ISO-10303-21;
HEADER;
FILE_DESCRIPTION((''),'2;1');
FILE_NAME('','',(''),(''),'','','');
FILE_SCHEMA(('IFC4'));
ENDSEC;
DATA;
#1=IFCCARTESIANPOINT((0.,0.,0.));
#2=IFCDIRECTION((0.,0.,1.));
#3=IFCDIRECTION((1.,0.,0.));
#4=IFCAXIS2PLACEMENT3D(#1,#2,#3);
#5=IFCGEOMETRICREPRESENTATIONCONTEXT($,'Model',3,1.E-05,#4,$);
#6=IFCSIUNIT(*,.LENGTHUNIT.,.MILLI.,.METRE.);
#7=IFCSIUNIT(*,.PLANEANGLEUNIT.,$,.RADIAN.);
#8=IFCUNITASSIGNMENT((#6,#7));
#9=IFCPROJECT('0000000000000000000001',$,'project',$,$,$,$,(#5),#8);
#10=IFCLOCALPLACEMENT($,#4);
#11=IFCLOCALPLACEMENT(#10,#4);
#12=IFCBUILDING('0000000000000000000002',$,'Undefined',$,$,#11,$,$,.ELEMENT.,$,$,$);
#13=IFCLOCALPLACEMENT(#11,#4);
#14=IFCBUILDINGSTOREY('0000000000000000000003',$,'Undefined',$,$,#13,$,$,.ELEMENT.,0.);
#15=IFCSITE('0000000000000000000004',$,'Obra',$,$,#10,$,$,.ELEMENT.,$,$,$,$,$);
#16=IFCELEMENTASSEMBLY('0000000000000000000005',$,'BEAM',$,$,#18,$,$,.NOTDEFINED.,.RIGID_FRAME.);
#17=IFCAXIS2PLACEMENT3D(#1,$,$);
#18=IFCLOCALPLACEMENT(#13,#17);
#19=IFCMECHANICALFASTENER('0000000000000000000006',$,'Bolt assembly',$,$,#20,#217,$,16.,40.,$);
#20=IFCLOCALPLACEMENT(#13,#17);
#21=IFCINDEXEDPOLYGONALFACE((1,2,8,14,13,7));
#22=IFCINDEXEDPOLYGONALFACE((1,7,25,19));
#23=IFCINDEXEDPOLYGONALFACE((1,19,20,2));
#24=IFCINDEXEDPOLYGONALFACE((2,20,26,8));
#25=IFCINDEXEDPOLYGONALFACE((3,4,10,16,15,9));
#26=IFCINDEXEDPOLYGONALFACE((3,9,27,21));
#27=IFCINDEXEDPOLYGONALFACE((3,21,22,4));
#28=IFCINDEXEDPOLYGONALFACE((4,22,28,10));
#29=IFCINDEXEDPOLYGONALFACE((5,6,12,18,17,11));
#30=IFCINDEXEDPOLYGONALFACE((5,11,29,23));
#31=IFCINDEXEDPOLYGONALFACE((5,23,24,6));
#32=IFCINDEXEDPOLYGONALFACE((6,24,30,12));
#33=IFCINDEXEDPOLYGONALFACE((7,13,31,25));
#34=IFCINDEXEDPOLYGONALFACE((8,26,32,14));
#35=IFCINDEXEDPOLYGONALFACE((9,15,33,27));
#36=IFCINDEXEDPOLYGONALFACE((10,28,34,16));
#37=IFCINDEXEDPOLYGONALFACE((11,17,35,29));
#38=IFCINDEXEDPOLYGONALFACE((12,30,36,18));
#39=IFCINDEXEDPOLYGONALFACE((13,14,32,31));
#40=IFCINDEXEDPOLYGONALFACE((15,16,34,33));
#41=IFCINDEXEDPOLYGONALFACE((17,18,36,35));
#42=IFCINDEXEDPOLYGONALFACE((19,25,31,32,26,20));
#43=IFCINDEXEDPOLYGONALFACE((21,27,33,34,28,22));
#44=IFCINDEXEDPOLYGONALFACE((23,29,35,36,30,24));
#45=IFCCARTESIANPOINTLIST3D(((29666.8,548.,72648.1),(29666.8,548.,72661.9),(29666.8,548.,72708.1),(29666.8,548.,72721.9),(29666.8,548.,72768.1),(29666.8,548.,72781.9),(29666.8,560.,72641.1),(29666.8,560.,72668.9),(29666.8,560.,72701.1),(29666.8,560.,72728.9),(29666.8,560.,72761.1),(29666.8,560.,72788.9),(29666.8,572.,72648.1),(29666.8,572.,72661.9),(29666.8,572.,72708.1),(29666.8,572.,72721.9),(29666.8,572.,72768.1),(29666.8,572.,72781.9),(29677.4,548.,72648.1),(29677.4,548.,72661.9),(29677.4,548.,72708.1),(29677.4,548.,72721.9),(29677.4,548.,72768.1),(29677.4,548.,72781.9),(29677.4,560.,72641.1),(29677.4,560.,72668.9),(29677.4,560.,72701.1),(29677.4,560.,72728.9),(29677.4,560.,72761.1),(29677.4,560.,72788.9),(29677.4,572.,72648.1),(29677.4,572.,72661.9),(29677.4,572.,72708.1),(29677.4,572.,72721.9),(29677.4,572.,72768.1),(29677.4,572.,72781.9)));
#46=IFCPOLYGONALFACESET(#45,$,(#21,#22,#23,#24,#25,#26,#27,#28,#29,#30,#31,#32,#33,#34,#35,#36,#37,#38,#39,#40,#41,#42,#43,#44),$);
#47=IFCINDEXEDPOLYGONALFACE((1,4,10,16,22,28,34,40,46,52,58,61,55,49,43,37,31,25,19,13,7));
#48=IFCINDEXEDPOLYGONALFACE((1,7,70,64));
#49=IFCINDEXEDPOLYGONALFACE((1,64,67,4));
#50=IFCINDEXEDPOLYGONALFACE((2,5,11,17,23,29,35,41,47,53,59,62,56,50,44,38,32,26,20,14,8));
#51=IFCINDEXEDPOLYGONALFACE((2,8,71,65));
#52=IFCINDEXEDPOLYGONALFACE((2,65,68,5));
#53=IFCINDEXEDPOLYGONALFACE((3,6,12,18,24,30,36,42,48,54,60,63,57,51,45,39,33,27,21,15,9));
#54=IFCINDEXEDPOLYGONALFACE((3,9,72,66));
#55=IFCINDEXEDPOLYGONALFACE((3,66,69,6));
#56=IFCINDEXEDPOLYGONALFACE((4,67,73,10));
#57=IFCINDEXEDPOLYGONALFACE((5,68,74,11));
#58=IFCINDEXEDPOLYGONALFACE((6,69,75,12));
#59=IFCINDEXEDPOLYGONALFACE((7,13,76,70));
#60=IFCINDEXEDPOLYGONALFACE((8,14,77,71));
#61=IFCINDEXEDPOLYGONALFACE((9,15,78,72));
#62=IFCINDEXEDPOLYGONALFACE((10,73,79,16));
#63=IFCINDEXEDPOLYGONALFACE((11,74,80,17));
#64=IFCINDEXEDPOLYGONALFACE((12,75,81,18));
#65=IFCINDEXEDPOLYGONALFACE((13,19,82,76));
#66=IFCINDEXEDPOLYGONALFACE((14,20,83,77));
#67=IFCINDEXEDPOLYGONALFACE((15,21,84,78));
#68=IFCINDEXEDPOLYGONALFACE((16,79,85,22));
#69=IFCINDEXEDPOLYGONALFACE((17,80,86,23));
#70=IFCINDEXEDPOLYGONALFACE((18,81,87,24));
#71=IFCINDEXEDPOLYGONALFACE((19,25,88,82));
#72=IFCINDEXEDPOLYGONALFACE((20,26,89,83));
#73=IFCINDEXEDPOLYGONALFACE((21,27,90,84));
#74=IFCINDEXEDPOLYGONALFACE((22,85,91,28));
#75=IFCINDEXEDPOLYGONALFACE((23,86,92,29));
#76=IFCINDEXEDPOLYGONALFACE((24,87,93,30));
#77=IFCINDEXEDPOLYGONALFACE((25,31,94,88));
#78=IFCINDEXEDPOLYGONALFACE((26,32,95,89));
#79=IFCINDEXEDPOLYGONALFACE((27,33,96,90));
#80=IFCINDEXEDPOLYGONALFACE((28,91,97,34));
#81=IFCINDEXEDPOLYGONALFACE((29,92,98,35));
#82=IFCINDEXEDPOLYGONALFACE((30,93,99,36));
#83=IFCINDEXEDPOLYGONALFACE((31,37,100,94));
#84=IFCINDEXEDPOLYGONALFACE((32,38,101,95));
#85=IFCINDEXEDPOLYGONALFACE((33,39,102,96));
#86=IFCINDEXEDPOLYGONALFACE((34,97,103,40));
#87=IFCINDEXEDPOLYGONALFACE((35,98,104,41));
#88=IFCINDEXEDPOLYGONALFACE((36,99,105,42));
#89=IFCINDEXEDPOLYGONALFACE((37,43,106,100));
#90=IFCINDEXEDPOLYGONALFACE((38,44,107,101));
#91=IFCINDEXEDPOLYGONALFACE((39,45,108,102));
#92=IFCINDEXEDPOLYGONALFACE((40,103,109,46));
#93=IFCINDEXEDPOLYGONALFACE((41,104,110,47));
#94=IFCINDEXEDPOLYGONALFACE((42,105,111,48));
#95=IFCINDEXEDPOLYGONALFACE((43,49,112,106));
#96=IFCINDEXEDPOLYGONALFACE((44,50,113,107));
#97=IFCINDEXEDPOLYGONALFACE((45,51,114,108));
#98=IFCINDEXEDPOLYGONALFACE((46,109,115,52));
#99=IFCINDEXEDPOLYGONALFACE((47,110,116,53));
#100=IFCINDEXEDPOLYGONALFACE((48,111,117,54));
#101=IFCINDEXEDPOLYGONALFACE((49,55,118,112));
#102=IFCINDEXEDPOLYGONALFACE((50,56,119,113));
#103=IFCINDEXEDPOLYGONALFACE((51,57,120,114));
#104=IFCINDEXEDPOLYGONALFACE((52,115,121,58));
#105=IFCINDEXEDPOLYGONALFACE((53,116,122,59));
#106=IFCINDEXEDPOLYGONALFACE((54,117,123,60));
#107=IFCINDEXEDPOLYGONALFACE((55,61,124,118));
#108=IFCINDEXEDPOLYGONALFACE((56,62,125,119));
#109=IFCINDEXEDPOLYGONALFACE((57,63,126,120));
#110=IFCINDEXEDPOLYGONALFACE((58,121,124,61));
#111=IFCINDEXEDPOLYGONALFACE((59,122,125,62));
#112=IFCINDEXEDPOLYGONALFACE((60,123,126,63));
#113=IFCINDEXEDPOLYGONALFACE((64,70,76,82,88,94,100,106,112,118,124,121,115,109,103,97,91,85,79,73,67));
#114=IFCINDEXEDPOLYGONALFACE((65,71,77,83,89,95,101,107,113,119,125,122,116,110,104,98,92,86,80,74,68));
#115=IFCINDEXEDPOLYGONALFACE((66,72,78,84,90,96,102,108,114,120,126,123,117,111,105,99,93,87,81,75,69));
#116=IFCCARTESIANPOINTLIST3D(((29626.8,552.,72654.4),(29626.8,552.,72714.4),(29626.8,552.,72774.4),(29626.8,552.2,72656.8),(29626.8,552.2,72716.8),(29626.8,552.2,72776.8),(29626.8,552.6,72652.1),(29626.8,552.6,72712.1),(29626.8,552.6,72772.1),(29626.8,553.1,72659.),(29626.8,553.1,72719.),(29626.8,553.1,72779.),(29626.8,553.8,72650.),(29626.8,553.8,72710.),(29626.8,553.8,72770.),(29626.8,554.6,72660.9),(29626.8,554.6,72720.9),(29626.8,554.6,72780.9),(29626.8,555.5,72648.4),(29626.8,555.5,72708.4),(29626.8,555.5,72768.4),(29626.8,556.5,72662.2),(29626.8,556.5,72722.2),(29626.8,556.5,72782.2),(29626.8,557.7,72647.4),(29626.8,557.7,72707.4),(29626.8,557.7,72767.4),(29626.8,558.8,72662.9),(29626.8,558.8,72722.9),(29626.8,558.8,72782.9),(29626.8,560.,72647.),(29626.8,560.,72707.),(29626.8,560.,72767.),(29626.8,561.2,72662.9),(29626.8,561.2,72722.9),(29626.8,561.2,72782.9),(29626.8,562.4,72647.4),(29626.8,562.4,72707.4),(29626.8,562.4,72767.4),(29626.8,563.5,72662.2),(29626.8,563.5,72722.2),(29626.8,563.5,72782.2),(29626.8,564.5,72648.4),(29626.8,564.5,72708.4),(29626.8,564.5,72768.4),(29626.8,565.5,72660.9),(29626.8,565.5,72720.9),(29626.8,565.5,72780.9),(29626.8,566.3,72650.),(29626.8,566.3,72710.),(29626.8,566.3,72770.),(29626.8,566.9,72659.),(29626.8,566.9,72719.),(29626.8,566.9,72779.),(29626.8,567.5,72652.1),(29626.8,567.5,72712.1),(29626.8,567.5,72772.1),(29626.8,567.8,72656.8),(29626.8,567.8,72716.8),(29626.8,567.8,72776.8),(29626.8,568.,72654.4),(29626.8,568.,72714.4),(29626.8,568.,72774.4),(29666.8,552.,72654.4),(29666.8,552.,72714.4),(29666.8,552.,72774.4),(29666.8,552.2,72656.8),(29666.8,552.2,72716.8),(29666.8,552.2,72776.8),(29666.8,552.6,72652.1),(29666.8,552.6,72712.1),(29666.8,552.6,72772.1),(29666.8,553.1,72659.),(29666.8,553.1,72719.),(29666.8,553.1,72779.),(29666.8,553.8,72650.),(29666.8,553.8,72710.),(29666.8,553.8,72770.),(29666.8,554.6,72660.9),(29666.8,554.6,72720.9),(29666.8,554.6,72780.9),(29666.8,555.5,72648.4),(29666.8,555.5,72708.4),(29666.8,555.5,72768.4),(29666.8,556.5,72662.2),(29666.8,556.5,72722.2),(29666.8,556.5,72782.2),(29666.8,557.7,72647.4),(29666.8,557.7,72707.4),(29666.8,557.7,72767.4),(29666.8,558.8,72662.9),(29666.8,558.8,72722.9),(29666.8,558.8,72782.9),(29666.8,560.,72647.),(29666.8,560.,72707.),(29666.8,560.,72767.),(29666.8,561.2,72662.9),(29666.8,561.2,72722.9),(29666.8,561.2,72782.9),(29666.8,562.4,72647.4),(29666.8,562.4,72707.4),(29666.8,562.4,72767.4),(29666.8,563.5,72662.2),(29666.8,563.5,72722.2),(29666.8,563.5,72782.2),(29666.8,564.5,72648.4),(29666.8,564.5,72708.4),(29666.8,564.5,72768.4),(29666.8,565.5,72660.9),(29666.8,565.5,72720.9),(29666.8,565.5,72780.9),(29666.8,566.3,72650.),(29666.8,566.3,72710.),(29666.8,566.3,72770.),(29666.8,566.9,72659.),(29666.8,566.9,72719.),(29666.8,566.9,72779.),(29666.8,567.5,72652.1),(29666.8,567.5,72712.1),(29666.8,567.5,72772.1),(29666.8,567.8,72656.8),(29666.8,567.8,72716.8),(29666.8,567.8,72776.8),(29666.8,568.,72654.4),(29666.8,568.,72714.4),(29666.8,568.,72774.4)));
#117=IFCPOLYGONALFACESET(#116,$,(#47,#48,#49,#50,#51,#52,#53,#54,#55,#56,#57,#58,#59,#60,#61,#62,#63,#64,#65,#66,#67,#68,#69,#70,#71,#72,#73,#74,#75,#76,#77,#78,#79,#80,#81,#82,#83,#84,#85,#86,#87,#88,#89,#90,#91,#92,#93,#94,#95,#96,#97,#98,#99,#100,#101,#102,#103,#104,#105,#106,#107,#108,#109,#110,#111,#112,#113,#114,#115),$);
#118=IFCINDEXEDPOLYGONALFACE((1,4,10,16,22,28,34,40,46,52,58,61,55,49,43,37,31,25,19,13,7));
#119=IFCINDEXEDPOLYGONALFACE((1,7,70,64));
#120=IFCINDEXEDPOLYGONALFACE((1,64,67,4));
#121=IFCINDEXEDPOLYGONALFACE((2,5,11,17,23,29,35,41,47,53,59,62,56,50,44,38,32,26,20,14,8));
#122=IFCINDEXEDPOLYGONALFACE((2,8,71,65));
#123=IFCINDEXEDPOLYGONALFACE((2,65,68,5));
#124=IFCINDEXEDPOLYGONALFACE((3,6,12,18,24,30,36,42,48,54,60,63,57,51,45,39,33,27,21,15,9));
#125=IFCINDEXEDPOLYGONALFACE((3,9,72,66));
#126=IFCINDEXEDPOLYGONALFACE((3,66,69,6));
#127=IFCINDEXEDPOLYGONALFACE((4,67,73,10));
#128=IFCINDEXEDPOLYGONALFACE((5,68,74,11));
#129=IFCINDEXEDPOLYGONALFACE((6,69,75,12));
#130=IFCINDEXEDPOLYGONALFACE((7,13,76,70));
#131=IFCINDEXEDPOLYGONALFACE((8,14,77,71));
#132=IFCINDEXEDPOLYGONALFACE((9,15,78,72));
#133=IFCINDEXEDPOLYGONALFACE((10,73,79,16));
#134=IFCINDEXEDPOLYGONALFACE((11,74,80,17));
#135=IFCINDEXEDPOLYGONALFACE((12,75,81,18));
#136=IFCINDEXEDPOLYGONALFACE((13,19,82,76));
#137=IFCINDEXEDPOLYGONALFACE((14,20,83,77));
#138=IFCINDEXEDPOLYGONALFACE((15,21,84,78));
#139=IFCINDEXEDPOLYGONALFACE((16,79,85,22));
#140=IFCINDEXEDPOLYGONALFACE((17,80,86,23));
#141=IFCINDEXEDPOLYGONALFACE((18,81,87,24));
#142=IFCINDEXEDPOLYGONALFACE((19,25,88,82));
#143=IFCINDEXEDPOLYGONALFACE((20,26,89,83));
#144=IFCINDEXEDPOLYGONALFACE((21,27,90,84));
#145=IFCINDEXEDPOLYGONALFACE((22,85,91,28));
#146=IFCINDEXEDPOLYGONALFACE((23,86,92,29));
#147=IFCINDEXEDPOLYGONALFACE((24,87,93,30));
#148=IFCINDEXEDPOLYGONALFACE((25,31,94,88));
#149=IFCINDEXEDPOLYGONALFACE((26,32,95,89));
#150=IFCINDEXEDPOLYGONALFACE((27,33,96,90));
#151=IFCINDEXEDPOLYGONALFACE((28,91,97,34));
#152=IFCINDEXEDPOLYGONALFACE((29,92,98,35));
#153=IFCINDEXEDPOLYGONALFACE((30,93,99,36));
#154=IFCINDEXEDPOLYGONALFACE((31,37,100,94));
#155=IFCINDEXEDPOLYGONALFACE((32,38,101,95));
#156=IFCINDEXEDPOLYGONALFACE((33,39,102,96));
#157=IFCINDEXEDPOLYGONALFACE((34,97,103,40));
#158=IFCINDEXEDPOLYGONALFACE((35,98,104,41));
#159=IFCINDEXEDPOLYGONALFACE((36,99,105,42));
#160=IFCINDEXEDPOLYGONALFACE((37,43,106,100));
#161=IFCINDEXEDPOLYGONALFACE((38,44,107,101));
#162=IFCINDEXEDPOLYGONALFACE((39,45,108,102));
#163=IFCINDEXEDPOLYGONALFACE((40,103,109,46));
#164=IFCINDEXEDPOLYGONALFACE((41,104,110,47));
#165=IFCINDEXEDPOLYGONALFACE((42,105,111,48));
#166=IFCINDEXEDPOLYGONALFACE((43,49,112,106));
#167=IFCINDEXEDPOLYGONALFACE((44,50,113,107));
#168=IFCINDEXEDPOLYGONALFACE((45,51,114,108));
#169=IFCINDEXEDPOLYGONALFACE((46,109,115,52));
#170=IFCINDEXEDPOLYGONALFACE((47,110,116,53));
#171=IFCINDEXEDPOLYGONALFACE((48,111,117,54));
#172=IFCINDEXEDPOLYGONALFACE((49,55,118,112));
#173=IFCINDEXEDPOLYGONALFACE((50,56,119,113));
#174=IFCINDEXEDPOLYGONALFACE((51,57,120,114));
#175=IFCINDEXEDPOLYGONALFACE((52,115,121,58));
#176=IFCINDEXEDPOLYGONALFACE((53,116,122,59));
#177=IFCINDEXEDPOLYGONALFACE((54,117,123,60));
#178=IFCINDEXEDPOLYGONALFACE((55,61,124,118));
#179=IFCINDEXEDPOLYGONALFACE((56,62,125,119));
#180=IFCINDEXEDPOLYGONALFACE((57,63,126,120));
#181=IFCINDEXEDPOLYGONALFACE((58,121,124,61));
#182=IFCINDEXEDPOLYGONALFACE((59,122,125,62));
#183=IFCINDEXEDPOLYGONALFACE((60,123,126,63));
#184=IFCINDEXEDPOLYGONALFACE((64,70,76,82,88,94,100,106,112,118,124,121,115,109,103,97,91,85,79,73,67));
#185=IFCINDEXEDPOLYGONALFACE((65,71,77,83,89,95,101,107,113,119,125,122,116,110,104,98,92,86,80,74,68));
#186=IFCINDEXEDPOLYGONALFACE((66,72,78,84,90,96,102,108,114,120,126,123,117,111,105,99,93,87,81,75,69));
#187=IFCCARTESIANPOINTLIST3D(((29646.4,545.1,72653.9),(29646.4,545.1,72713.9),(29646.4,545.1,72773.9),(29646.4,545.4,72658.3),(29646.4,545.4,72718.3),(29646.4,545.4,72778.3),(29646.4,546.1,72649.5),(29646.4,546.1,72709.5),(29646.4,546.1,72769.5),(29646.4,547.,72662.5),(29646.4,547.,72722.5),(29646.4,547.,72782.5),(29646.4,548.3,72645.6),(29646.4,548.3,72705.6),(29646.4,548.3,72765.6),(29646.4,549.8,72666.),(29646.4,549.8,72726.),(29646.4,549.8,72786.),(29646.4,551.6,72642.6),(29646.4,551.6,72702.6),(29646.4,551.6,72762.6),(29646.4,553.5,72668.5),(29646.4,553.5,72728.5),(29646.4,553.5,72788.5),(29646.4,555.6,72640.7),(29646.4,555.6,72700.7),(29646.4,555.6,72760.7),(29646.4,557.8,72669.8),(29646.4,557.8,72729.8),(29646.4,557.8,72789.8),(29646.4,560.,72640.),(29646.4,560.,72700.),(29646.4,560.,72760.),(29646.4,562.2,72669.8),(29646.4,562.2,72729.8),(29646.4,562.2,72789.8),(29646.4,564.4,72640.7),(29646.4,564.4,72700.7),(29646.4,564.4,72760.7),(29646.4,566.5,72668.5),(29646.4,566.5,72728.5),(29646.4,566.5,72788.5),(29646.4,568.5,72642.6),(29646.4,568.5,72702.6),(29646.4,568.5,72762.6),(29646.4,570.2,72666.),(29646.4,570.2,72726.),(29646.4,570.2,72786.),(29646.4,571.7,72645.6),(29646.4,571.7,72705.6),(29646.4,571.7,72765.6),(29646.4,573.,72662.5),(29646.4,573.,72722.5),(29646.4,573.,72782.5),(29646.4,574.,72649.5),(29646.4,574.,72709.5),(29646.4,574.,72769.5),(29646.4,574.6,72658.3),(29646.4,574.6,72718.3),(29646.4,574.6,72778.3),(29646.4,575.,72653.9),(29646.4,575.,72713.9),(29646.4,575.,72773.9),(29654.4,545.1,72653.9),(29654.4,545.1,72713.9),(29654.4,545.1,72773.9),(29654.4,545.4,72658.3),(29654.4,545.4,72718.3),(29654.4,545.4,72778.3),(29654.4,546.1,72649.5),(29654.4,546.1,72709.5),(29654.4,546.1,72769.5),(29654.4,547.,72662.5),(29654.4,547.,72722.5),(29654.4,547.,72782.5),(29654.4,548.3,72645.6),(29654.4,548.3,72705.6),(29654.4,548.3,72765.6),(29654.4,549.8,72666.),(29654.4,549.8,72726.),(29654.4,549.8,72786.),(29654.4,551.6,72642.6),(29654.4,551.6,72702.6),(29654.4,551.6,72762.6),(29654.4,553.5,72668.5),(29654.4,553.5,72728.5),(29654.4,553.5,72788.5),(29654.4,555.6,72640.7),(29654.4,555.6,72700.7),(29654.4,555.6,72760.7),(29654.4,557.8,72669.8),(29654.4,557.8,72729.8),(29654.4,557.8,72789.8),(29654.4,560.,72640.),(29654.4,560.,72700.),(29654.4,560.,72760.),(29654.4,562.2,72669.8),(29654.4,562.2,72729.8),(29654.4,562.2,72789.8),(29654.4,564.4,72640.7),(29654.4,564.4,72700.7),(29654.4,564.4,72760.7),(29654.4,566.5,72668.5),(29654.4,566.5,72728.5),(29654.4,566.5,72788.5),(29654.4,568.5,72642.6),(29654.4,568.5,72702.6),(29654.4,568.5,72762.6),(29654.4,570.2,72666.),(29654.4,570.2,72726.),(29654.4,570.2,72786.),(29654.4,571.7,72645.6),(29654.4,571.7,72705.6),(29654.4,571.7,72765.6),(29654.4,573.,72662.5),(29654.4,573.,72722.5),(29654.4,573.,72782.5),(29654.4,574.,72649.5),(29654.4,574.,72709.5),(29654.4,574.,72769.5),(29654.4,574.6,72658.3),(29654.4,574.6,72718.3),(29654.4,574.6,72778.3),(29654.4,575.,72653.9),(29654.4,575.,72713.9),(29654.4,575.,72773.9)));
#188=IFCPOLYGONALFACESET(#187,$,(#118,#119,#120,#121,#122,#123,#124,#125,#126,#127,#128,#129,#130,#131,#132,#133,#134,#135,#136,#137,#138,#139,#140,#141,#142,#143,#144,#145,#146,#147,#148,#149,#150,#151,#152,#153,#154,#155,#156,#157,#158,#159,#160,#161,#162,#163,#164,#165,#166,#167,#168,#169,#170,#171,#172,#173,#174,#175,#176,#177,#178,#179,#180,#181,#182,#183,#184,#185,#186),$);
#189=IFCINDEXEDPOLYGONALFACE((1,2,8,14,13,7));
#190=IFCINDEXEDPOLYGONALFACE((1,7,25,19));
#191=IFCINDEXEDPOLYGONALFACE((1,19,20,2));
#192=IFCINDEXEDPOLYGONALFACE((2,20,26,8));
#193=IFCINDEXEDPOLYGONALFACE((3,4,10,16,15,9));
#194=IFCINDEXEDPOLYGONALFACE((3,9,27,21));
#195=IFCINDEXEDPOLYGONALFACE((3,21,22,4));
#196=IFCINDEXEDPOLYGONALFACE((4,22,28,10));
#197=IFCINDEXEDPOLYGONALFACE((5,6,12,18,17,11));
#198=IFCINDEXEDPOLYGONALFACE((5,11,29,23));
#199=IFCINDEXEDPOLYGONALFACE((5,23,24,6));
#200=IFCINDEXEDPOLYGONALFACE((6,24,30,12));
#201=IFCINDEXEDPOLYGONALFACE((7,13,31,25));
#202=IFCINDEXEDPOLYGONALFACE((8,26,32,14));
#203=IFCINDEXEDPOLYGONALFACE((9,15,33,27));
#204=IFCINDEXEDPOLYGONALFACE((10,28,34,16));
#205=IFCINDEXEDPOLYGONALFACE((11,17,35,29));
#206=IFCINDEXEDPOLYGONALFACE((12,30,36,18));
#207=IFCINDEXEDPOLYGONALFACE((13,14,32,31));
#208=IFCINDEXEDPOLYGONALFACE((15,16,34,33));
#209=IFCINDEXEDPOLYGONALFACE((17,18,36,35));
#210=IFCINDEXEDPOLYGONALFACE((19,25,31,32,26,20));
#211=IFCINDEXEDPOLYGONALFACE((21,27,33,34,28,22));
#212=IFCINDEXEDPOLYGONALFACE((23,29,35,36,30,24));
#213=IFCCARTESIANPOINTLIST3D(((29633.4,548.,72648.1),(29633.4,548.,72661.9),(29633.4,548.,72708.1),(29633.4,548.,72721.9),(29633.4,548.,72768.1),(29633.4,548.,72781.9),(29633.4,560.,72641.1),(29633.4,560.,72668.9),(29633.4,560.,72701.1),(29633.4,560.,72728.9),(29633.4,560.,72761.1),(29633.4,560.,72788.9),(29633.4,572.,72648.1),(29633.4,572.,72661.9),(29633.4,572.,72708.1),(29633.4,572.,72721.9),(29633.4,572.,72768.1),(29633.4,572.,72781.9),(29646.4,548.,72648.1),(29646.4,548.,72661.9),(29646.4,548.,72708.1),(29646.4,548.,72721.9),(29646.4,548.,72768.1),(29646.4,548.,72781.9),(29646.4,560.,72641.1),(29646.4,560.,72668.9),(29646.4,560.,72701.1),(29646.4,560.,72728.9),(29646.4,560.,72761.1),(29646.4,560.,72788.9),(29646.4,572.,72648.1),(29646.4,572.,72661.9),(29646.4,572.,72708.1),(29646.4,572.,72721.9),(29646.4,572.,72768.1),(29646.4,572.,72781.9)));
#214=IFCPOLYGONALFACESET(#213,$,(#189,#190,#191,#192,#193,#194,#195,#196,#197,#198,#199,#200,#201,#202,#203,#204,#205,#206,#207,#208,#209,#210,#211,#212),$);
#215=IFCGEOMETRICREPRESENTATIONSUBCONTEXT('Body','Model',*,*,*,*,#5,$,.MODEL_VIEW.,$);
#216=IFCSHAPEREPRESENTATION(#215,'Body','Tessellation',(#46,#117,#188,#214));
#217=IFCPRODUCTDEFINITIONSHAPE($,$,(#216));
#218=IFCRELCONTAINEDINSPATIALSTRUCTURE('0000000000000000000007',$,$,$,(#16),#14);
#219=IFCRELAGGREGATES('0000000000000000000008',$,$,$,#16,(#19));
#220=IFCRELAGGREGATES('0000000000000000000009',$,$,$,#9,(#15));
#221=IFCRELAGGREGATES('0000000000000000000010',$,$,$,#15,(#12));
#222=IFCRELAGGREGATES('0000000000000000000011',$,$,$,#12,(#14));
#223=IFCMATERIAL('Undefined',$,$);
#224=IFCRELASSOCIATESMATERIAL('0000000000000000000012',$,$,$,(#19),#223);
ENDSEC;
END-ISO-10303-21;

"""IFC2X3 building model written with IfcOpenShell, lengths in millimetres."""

from ifc_helpers import new_model, si_unit, frame, origin_with_axes, origin_2d_with_axis, place, context, subcontext, project, spatial, polyline, circle, outline, extrude, source, transform, mapped, material, element, aggregate, save


model = new_model("IFC2X3")

# Units and contexts
model_context = context("Model", 3, precision=1e-05, world=origin_with_axes())
body_context = subcontext(model_context, "Body", "Model", "MODEL_VIEW")
ifc_project = project(units=[si_unit("LENGTHUNIT", "METRE", prefix="MILLI"), si_unit("PLANEANGLEUNIT", "RADIAN")], contexts=[model_context])

# Site, building, storey
site_placement = place(None, origin_with_axes())
site = spatial("IfcSite", under=ifc_project, at=site_placement, Name="Obra", CompositionType="ELEMENT")
building_placement = place(site_placement, origin_with_axes())
building = spatial("IfcBuilding", under=site, at=building_placement, Name="Undefined", CompositionType="ELEMENT")
storey_placement = place(building_placement, origin_with_axes())
storey = spatial("IfcBuildingStorey", under=building, at=storey_placement, Name="Undefined", CompositionType="ELEMENT", Elevation=0.0)

# Shared definitions
ifc_material = material(Name="Undefined")

# Element assembly, mechanical fastener
assembly_1_placement = place(storey_placement, origin_with_axes())
assembly_1 = element("IfcElementAssembly", 1, at=assembly_1_placement, inside=storey, Name="BEAM", AssemblyPlace="NOTDEFINED", PredefinedType="RIGID_FRAME")
shared_shape_1 = source(origin_with_axes(), body_context, "Body", "SweptSolid", [
    extrude(outline(polyline([(13.9, 0.0), (6.9, 12.0), (-6.9, 12.0), (-13.9, 0.0), (-6.9, -12.0), (6.9, -12.0), (13.9, 0.0)])), frame((0.0, -19.7, 0.0), z_axis=(0.0, 1.0, 0.0), x_axis=(1.0, 0.0, 0.0)), (0.0, 0.0, 1.0), 10.6),
    extrude(circle(Radius=8.0, at=origin_2d_with_axis()), frame((0.0, -9.1, 0.0), z_axis=(0.0, 1.0, 0.0), x_axis=(1.0, 0.0, 0.0)), (0.0, 0.0, 1.0), 40.0),
    extrude(circle(Radius=15.0, at=origin_2d_with_axis()), frame((0.0, 3.3, 0.0), z_axis=(0.0, 1.0, 0.0), x_axis=(1.0, 0.0, 0.0)), (0.0, 0.0, 1.0), 8.0),
    extrude(outline(polyline([(13.9, 0.0), (6.9, 12.0), (-6.9, 12.0), (-13.9, 0.0), (-6.9, -12.0), (6.9, -12.0), (13.9, 0.0)])), frame((0.0, 11.3, 0.0), z_axis=(0.0, 1.0, 0.0), x_axis=(1.0, 0.0, 0.0)), (0.0, 0.0, 1.0), 13.0),
])
mechanical_fastener_1_placement = place(assembly_1_placement, frame((29657.7, 510.0, 72835.0), z_axis=(-0.000002, 1.0, 0.0), x_axis=(0.0, 0.0, -1.0)))
mechanical_fastener_1 = element("IfcMechanicalFastener", 2, at=mechanical_fastener_1_placement, material=ifc_material, Name="Bolt assembly", NominalDiameter=16.0, NominalLength=40.0, context=body_context, shape_type="MappedRepresentation", body=[
    mapped(shared_shape_1, transform((60.0, 0.0, 50.0))),
    mapped(shared_shape_1, transform((120.0, 0.0, 50.0))),
    mapped(shared_shape_1, transform((180.0, 0.0, 50.0))),
])
aggregate(assembly_1, [mechanical_fastener_1])

save(model, "model.ifc")
